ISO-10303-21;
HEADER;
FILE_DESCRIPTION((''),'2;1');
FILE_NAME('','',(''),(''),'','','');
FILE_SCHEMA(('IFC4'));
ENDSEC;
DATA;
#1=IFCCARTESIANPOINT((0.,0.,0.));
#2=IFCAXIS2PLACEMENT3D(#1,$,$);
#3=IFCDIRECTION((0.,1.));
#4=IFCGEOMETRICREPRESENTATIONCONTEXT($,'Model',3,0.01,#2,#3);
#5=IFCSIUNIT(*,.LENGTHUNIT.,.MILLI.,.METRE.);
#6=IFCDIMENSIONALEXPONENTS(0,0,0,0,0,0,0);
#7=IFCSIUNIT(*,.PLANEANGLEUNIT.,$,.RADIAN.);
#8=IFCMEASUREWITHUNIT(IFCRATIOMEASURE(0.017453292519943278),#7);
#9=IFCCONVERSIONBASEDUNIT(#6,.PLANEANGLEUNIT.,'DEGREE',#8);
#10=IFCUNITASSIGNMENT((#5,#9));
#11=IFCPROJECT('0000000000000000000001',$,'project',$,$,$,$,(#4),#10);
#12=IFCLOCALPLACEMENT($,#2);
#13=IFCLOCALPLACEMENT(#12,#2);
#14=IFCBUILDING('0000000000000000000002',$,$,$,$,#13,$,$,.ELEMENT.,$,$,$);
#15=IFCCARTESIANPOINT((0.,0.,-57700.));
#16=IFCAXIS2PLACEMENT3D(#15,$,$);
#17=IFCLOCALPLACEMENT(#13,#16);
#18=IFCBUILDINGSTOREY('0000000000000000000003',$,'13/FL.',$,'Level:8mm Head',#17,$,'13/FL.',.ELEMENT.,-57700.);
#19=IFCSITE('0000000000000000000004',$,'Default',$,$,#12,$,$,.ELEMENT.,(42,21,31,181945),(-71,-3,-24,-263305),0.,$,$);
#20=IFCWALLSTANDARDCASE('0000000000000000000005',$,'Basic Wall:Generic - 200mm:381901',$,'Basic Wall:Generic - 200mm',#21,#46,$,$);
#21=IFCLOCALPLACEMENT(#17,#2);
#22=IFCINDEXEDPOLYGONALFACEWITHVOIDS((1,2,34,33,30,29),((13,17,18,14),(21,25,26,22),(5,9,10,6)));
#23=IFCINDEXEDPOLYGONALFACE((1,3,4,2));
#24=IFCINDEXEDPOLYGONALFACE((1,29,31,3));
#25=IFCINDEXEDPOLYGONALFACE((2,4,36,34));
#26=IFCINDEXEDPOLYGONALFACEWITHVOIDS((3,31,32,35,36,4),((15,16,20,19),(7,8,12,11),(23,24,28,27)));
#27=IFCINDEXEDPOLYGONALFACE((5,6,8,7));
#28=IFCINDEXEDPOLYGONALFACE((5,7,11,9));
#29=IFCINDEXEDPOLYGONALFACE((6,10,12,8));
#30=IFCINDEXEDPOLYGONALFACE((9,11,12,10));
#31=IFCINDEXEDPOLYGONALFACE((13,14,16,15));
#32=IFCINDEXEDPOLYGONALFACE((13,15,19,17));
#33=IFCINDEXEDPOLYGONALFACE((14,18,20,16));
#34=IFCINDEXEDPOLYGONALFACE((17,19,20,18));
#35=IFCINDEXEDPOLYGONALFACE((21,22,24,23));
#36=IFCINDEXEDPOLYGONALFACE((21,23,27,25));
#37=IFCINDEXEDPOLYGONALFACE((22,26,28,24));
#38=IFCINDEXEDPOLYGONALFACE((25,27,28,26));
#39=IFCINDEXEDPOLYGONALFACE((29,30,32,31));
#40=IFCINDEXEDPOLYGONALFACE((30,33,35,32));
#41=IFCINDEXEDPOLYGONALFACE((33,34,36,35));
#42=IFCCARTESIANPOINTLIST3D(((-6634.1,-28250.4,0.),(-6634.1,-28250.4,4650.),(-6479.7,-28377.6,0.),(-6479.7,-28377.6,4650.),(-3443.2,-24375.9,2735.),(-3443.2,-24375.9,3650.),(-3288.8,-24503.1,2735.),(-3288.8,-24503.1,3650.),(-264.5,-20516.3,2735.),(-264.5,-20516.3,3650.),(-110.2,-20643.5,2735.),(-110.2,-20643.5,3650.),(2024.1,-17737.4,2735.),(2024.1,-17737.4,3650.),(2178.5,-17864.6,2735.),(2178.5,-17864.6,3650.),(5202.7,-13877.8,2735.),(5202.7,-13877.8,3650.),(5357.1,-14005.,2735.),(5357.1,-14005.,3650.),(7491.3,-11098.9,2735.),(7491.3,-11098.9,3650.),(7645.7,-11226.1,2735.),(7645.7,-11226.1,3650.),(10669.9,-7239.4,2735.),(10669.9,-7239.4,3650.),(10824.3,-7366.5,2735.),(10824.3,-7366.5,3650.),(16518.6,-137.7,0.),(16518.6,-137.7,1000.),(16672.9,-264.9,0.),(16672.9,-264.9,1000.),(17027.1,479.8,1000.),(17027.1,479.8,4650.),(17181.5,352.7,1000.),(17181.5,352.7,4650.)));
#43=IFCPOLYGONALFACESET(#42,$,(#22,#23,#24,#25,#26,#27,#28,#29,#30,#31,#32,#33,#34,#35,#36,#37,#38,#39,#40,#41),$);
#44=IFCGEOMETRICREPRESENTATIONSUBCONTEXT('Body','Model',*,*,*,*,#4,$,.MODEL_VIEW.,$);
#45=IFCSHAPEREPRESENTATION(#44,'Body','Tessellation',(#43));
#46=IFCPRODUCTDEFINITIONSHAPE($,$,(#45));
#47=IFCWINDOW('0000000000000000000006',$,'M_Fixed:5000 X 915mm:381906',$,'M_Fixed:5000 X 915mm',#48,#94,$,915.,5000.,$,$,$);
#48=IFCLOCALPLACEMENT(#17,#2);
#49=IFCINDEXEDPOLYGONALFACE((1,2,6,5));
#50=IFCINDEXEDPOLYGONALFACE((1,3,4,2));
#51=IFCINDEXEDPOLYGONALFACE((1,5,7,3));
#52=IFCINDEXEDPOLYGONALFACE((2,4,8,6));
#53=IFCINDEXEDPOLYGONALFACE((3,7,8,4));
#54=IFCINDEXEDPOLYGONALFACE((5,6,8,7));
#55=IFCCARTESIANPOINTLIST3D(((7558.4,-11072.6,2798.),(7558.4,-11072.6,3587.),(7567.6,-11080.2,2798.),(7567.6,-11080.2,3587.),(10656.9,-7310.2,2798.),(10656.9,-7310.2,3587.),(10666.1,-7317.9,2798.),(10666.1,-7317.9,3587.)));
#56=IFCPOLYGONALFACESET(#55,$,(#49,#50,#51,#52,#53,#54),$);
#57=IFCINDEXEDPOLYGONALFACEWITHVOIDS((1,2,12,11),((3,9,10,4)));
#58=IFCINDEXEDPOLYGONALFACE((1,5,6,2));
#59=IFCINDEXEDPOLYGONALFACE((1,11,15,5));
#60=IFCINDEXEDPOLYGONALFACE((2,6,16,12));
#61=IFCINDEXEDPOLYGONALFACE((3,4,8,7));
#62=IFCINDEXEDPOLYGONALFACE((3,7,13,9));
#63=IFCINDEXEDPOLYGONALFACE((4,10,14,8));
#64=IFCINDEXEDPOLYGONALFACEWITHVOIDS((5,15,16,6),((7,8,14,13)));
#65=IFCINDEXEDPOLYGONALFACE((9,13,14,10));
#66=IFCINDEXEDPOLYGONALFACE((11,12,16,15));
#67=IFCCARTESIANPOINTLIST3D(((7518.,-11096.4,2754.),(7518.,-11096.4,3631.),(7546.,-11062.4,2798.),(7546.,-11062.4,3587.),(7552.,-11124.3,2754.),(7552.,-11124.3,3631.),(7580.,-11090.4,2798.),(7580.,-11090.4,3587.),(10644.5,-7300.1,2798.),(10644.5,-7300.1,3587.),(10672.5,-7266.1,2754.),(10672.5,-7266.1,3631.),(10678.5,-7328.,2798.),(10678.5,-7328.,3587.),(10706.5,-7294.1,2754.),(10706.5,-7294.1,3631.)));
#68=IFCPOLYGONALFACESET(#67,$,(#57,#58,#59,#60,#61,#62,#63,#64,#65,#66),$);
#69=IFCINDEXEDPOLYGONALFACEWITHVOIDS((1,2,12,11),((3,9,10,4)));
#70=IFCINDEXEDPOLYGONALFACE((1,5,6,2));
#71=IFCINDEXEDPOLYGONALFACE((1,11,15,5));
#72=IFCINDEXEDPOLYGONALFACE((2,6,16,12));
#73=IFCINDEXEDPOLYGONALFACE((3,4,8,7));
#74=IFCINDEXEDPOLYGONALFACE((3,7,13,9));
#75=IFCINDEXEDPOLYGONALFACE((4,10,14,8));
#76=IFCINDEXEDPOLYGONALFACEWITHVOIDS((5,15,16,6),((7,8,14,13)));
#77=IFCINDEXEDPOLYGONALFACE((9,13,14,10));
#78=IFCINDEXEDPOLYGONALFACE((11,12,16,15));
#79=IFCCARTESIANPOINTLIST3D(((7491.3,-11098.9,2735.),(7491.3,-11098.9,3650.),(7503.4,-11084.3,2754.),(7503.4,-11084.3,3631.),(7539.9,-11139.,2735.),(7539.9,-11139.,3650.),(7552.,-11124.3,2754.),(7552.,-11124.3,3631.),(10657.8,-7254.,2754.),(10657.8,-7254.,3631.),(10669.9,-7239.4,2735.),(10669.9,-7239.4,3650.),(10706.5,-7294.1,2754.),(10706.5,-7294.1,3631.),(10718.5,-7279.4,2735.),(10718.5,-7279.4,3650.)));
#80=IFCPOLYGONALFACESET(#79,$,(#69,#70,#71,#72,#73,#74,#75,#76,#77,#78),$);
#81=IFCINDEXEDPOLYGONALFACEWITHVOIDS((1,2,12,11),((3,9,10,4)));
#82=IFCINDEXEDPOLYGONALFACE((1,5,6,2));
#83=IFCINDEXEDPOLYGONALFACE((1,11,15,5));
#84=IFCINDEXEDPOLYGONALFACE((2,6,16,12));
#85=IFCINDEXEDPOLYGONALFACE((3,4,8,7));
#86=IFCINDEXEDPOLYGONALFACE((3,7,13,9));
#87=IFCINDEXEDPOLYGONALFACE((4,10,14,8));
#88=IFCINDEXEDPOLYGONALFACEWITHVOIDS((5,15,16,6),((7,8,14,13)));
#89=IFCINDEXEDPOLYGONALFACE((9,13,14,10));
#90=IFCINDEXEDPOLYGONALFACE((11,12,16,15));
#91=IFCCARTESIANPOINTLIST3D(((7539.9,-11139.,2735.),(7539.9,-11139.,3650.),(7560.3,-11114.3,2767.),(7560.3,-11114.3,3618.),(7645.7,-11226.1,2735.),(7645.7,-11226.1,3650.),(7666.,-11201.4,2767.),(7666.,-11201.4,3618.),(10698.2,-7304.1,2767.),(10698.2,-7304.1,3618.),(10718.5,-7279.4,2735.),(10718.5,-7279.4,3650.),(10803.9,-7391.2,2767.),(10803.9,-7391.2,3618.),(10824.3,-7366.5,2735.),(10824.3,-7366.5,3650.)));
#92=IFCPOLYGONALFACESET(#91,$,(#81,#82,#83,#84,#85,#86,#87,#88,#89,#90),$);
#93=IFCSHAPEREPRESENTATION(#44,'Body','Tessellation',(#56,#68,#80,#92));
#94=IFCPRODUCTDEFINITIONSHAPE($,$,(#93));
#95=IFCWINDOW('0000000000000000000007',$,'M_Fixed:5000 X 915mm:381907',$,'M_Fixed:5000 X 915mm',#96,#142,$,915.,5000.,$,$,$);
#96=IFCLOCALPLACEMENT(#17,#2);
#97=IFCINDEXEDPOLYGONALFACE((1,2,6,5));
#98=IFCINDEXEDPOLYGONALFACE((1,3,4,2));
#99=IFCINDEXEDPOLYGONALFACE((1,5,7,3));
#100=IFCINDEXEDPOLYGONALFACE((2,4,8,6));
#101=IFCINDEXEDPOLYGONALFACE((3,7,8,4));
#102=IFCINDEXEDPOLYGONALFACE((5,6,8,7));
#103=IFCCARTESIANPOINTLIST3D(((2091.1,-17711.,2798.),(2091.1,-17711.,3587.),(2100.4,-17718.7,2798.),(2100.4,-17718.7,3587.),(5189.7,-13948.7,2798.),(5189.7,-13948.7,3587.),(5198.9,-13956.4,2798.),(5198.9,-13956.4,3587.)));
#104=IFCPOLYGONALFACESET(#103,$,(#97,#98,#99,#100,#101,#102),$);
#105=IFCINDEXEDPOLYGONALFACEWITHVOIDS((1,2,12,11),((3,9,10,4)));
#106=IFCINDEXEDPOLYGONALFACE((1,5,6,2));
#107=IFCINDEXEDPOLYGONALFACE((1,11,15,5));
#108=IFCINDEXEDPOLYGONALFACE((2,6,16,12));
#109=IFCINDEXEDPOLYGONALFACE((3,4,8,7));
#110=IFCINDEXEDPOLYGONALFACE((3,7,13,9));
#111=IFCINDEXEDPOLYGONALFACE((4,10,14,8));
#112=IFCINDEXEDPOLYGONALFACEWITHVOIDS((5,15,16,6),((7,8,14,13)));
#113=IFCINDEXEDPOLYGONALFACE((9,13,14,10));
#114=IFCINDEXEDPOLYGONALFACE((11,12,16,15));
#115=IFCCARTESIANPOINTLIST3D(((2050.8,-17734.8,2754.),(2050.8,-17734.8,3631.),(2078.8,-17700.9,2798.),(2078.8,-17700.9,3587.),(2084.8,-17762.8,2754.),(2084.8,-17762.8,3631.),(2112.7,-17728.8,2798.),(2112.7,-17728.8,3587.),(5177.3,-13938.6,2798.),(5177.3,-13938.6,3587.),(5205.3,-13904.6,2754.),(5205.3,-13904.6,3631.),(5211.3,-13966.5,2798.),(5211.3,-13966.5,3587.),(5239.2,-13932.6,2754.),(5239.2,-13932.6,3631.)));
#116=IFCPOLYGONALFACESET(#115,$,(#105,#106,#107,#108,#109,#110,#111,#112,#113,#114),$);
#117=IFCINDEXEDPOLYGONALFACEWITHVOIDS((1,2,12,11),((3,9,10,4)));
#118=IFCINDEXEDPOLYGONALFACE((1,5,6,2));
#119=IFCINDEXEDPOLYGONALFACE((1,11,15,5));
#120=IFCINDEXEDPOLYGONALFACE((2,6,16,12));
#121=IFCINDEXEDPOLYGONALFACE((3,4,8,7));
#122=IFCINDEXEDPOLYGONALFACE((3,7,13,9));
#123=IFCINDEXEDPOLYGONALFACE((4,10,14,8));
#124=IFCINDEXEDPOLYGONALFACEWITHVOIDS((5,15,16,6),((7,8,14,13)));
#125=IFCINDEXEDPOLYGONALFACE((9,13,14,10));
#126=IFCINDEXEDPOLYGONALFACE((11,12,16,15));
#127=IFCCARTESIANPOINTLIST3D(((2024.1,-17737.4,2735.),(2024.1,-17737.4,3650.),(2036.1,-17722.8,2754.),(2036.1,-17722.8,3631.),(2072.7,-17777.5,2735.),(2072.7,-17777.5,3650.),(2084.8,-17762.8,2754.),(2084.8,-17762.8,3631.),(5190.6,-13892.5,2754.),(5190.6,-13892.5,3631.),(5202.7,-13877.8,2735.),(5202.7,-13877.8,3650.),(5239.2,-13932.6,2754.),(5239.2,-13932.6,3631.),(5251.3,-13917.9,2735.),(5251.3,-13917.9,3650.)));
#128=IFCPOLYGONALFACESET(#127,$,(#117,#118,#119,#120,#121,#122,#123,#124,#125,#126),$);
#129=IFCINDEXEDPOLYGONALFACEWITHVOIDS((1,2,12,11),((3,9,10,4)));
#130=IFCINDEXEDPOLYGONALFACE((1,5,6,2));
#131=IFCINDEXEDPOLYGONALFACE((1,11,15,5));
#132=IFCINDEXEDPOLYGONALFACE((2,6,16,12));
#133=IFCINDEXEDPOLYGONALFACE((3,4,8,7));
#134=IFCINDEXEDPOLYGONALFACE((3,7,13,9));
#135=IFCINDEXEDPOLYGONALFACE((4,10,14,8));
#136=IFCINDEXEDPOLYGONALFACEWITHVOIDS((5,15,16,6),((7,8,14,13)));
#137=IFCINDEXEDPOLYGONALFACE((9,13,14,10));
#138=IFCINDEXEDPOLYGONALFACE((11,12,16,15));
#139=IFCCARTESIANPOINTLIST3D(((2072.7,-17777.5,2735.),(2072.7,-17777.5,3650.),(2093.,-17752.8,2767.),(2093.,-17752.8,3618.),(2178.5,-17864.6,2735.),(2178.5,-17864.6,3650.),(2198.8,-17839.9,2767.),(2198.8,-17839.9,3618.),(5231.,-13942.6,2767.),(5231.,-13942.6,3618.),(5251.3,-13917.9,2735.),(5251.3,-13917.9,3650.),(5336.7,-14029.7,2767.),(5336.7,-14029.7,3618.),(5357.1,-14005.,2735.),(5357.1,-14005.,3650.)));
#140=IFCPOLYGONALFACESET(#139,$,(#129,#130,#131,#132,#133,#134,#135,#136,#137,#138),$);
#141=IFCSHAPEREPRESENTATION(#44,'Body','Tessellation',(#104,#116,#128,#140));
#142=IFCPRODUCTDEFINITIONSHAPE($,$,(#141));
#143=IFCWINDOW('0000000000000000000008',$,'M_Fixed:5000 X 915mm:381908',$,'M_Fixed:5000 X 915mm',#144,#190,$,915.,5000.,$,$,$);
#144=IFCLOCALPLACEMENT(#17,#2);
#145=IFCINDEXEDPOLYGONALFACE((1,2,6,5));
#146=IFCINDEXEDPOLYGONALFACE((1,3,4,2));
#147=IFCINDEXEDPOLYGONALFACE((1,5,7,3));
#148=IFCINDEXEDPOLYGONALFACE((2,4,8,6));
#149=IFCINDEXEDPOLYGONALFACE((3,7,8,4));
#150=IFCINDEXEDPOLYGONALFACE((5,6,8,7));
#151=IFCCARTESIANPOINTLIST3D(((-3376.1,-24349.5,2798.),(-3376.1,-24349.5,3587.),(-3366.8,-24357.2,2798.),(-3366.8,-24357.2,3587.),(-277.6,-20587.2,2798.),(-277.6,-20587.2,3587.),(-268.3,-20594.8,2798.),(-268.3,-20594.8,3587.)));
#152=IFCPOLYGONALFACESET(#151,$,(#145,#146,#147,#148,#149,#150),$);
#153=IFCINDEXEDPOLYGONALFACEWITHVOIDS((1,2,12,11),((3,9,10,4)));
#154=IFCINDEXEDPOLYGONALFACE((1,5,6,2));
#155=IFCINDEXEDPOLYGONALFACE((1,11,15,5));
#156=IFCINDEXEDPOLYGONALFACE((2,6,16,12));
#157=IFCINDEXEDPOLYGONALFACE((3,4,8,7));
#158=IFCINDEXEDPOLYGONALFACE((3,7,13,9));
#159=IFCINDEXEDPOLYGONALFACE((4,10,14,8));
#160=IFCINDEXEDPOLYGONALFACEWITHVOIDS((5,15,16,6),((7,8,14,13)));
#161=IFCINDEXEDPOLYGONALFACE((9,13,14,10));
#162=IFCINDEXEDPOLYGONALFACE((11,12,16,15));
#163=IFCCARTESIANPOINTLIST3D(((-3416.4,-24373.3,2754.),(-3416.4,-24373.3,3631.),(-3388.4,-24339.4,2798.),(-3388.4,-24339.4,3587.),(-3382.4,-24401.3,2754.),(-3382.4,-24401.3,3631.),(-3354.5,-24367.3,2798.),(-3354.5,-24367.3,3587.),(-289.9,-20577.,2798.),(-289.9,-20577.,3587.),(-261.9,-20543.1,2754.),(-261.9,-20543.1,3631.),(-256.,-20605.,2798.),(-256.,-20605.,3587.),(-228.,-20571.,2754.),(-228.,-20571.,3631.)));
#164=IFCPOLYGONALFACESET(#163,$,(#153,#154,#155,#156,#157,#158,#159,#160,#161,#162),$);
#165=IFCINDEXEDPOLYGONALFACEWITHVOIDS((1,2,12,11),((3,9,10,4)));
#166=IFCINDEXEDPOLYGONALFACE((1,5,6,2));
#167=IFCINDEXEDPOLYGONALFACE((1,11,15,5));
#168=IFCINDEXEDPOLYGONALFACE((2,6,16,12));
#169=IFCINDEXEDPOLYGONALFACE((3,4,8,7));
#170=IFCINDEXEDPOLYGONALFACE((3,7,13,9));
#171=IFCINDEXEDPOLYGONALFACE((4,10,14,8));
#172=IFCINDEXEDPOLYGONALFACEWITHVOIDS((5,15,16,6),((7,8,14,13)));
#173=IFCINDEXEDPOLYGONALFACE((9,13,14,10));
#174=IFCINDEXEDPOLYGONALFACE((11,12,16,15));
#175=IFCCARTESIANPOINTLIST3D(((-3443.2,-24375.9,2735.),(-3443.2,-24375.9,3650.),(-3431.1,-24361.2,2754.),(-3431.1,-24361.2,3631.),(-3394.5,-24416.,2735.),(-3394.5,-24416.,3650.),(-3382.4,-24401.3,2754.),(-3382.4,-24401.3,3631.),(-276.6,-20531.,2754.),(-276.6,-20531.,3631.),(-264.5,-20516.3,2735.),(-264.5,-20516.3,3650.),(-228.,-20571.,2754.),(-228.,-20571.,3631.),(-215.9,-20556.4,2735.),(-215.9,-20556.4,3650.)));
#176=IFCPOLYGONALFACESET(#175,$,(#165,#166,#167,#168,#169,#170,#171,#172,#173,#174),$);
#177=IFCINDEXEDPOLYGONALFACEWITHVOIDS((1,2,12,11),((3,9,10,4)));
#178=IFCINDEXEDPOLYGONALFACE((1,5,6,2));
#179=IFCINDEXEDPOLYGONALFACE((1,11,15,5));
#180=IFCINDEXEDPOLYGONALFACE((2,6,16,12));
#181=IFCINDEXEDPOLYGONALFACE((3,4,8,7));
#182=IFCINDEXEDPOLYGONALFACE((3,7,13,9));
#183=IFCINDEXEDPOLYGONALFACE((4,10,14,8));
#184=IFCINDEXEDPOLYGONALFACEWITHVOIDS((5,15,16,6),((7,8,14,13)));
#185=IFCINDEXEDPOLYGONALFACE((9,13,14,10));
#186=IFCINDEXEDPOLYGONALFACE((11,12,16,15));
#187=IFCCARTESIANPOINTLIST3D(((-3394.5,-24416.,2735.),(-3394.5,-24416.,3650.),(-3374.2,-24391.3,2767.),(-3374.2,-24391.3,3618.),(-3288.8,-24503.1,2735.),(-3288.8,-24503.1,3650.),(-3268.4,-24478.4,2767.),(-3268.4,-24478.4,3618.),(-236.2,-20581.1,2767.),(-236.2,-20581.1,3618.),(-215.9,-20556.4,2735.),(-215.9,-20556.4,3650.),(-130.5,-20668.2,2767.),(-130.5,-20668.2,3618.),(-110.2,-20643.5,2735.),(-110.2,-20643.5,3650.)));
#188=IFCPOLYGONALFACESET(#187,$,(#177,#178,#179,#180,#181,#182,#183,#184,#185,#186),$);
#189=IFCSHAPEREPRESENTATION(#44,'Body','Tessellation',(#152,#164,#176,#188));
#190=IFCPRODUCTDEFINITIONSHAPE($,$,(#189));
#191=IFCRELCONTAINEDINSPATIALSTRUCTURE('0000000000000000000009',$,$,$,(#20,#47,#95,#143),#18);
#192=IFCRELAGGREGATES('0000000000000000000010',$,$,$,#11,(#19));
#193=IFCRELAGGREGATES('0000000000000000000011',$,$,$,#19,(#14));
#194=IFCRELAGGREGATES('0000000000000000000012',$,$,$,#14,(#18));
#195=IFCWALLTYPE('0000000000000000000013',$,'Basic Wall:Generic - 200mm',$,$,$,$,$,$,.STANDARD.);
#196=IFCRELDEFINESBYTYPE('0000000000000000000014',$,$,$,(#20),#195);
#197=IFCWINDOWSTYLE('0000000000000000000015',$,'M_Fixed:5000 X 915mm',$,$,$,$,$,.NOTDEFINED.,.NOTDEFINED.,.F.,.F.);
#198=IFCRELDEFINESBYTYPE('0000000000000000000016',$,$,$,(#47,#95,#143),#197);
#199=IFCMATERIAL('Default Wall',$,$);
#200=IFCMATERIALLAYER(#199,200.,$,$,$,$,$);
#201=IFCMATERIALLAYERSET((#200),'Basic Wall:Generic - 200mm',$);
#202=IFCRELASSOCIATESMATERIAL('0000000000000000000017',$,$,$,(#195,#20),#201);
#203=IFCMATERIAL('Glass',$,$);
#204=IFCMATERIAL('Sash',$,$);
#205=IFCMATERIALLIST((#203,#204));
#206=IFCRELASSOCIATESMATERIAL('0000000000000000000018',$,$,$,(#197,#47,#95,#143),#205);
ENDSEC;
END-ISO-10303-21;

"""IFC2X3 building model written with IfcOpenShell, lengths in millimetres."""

from ifc_helpers import new_model, entity, si_unit, converted_unit, direction, frame, frame_2d, origin, place, context, subcontext, project, spatial, polyline, rectangle, outline, extrude, source, transform, mapped, material, material_list, layer, layer_set, layer_usage, type_object, type_shapes, element, fill, save


model = new_model("IFC2X3")

# Units and contexts
model_context = context("Model", 3, precision=0.01, world=origin(), true_north=direction((0.0, 1.0)))
body_context = subcontext(model_context, "Body", "Model", "MODEL_VIEW")
ifc_project = project(units=[si_unit("LENGTHUNIT", "METRE", prefix="MILLI"), converted_unit("PLANEANGLEUNIT", "DEGREE", entity("IfcRatioMeasure", 0.017453292519943278), si_unit("PLANEANGLEUNIT", "RADIAN"), dimensions=[0, 0, 0, 0, 0, 0, 0])], contexts=[model_context])

# Site, building, storey
site_placement = place(None, origin())
site = spatial("IfcSite", under=ifc_project, at=site_placement, Name="Default", CompositionType="ELEMENT", RefLatitude=(42, 21, 31, 181945), RefLongitude=(-71, -3, -24, -263305), RefElevation=0.0)
building_placement = place(site_placement, origin())
building = spatial("IfcBuilding", under=site, at=building_placement, CompositionType="ELEMENT")
storey_placement = place(building_placement, frame((0.0, 0.0, -57700.0)))
storey = spatial("IfcBuildingStorey", under=building, at=storey_placement, Name="13/FL.", ObjectType="Level:8mm Head", LongName="13/FL.", CompositionType="ELEMENT", Elevation=-57700.0)

# Shared definitions
ifc_material_1 = material(Name="Default Wall")
ifc_layer = layer(ifc_material_1, 200.0)
ifc_layer_set = layer_set([ifc_layer], Name="Basic Wall:Generic - 200mm")
ifc_layer_usage = layer_usage(ifc_layer_set, "AXIS2", "NEGATIVE", 100.0)
wall_type = type_object("IfcWallType", Name="Basic Wall:Generic - 200mm", PredefinedType="STANDARD", material=ifc_layer_set)

# Wall, openings, windows
wall_1_placement = place(storey_placement, frame((17104.3, 416.2, 0.0), z_axis=(0.0, 0.0, 1.0), x_axis=(-0.635723, -0.771917, 0.0)))
wall_1 = element("IfcWallStandardCase", 1, at=wall_1_placement, inside=storey, type_object=wall_type, material=ifc_layer_usage, Name="Basic Wall:Generic - 200mm:381901", ObjectType="Basic Wall:Generic - 200mm", context=body_context, shape_type="SweptSolid", body=[
    extrude(rectangle(XDim=37219.3, YDim=200.0, at=frame_2d((18609.7, 0.0), x_axis=(-1.0, 0.0))), origin(), (0.0, 0.0, 1.0), 4650.0),
])
opening_1_placement = place(wall_1_placement, origin())
element("IfcOpeningElement", 2, at=opening_1_placement, cuts=wall_1, ObjectType="Opening", context=body_context, shape_type="SweptSolid", body=[
    extrude(rectangle(XDim=1000.0, YDim=1012.7, at=frame_2d((0.0, 0.0), x_axis=(1.0, 0.0))), frame((293.7, -183.3, 500.0), z_axis=(0.0, 1.0, 0.0), x_axis=(0.0, 0.0, -1.0)), (0.0, 0.0, 1.0), 1010.1),
])
opening_2_placement = place(wall_1_placement, frame((15000.0, 100.0, 2735.0)))
opening_2 = element("IfcOpeningElement", 3, at=opening_2_placement, cuts=wall_1, ObjectType="Opening", context=body_context, shape_type="SweptSolid", body=[
    extrude(rectangle(XDim=915.0, YDim=5000.0, at=frame_2d((457.5, 2500.0), x_axis=(1.0, 0.0))), frame((0.0, 0.0, 0.0), z_axis=(0.0, -1.0, 0.0), x_axis=(0.0, 0.0, 1.0)), (0.0, 0.0, 1.0), 200.0),
])
opening_3_placement = place(wall_1_placement, frame((23600.0, 100.0, 2735.0)))
opening_3 = element("IfcOpeningElement", 4, at=opening_3_placement, cuts=wall_1, ObjectType="Opening", context=body_context, shape_type="SweptSolid", body=[
    extrude(rectangle(XDim=915.0, YDim=5000.0, at=frame_2d((457.5, 2500.0), x_axis=(1.0, 0.0))), frame((0.0, 0.0, 0.0), z_axis=(0.0, -1.0, 0.0), x_axis=(0.0, 0.0, 1.0)), (0.0, 0.0, 1.0), 200.0),
])
opening_4_placement = place(wall_1_placement, frame((32200.0, 100.0, 2735.0)))
opening_4 = element("IfcOpeningElement", 5, at=opening_4_placement, cuts=wall_1, ObjectType="Opening", context=body_context, shape_type="SweptSolid", body=[
    extrude(rectangle(XDim=915.0, YDim=5000.0, at=frame_2d((457.5, 2500.0), x_axis=(1.0, 0.0))), frame((0.0, 0.0, 0.0), z_axis=(0.0, -1.0, 0.0), x_axis=(0.0, 0.0, 1.0)), (0.0, 0.0, 1.0), 200.0),
])
ifc_material_2 = material(Name="Glass")
ifc_material_3 = material(Name="Sash")
ifc_material_list = material_list([ifc_material_2, ifc_material_3])
window_style_1 = type_object("IfcWindowStyle", Name="M_Fixed:5000 X 915mm", ConstructionType="NOTDEFINED", OperationType="NOTDEFINED", ParameterTakesPrecedence=False, Sizeable=False, material=ifc_material_list)
shared_shape_1 = source(origin(), body_context, "Body", "SweptSolid", [
    extrude(rectangle(XDim=12.0, YDim=4874.0, at=frame_2d((0.0, 0.0), x_axis=(1.0, 0.0))), frame((2500.0, 159.0, 63.0), z_axis=(0.0, 0.0, 1.0), x_axis=(0.0, -1.0, 0.0)), (0.0, 0.0, 1.0), 789.0),
    extrude(outline(polyline([(-2481.0, -438.5), (2481.0, -438.5), (2481.0, 438.5), (-2481.0, 438.5), (-2481.0, -438.5)]), holes=[polyline([(-2437.0, -394.5), (-2437.0, 394.5), (2437.0, 394.5), (2437.0, -394.5), (-2437.0, -394.5)])]), frame((2500.0, 137.0, 457.5), z_axis=(0.0, 1.0, 0.0), x_axis=(1.0, 0.0, 0.0)), (0.0, 0.0, 1.0), 44.0),
    extrude(outline(polyline([(-2500.0, -457.5), (2500.0, -457.5), (2500.0, 457.5), (-2500.0, 457.5), (-2500.0, -457.5)]), holes=[polyline([(-2481.0, -438.5), (-2481.0, 438.5), (2481.0, 438.5), (2481.0, -438.5), (-2481.0, -438.5)])]), frame((2500.0, 137.0, 457.5), z_axis=(0.0, 1.0, 0.0), x_axis=(1.0, 0.0, 0.0)), (0.0, 0.0, 1.0), 63.0),
    extrude(outline(polyline([(-2500.0, -457.5), (2500.0, -457.5), (2500.0, 457.5), (-2500.0, 457.5), (-2500.0, -457.5)]), holes=[polyline([(-2468.0, -425.5), (-2468.0, 425.5), (2468.0, 425.5), (2468.0, -425.5), (-2468.0, -425.5)])]), frame((2500.0, 0.0, 457.5), z_axis=(0.0, 1.0, 0.0), x_axis=(1.0, 0.0, 0.0)), (0.0, 0.0, 1.0), 137.0),
])
type_shapes(window_style_1, [shared_shape_1])
window_1_placement = place(opening_2_placement, frame((0.0, 0.0, 0.0), z_axis=(0.0, 0.0, 1.0), x_axis=(-1.0, 0.0, 0.0)))
window_1 = element("IfcWindow", 6, at=window_1_placement, inside=storey, type_object=window_style_1, material=ifc_material_list, Name="M_Fixed:5000 X 915mm:381906", ObjectType="M_Fixed:5000 X 915mm", OverallHeight=915.0, OverallWidth=5000.0, context=body_context, shape_type="MappedRepresentation", body=[
    mapped(shared_shape_1, transform((0.0, 0.0, 0.0), scale=1.0)),
])
fill(opening_2, window_1)
window_2_placement = place(opening_3_placement, frame((0.0, 0.0, 0.0), z_axis=(0.0, 0.0, 1.0), x_axis=(-1.0, 0.0, 0.0)))
window_2 = element("IfcWindow", 7, at=window_2_placement, inside=storey, type_object=window_style_1, material=ifc_material_list, Name="M_Fixed:5000 X 915mm:381907", ObjectType="M_Fixed:5000 X 915mm", OverallHeight=915.0, OverallWidth=5000.0, context=body_context, shape_type="MappedRepresentation", body=[
    mapped(shared_shape_1, transform((0.0, 0.0, 0.0), scale=1.0)),
])
fill(opening_3, window_2)
window_3_placement = place(opening_4_placement, frame((0.0, 0.0, 0.0), z_axis=(0.0, 0.0, 1.0), x_axis=(-1.0, 0.0, 0.0)))
window_3 = element("IfcWindow", 8, at=window_3_placement, inside=storey, type_object=window_style_1, material=ifc_material_list, Name="M_Fixed:5000 X 915mm:381908", ObjectType="M_Fixed:5000 X 915mm", OverallHeight=915.0, OverallWidth=5000.0, context=body_context, shape_type="MappedRepresentation", body=[
    mapped(shared_shape_1, transform((0.0, 0.0, 0.0), scale=1.0)),
])
fill(opening_4, window_3)

save(model, "model.ifc")
